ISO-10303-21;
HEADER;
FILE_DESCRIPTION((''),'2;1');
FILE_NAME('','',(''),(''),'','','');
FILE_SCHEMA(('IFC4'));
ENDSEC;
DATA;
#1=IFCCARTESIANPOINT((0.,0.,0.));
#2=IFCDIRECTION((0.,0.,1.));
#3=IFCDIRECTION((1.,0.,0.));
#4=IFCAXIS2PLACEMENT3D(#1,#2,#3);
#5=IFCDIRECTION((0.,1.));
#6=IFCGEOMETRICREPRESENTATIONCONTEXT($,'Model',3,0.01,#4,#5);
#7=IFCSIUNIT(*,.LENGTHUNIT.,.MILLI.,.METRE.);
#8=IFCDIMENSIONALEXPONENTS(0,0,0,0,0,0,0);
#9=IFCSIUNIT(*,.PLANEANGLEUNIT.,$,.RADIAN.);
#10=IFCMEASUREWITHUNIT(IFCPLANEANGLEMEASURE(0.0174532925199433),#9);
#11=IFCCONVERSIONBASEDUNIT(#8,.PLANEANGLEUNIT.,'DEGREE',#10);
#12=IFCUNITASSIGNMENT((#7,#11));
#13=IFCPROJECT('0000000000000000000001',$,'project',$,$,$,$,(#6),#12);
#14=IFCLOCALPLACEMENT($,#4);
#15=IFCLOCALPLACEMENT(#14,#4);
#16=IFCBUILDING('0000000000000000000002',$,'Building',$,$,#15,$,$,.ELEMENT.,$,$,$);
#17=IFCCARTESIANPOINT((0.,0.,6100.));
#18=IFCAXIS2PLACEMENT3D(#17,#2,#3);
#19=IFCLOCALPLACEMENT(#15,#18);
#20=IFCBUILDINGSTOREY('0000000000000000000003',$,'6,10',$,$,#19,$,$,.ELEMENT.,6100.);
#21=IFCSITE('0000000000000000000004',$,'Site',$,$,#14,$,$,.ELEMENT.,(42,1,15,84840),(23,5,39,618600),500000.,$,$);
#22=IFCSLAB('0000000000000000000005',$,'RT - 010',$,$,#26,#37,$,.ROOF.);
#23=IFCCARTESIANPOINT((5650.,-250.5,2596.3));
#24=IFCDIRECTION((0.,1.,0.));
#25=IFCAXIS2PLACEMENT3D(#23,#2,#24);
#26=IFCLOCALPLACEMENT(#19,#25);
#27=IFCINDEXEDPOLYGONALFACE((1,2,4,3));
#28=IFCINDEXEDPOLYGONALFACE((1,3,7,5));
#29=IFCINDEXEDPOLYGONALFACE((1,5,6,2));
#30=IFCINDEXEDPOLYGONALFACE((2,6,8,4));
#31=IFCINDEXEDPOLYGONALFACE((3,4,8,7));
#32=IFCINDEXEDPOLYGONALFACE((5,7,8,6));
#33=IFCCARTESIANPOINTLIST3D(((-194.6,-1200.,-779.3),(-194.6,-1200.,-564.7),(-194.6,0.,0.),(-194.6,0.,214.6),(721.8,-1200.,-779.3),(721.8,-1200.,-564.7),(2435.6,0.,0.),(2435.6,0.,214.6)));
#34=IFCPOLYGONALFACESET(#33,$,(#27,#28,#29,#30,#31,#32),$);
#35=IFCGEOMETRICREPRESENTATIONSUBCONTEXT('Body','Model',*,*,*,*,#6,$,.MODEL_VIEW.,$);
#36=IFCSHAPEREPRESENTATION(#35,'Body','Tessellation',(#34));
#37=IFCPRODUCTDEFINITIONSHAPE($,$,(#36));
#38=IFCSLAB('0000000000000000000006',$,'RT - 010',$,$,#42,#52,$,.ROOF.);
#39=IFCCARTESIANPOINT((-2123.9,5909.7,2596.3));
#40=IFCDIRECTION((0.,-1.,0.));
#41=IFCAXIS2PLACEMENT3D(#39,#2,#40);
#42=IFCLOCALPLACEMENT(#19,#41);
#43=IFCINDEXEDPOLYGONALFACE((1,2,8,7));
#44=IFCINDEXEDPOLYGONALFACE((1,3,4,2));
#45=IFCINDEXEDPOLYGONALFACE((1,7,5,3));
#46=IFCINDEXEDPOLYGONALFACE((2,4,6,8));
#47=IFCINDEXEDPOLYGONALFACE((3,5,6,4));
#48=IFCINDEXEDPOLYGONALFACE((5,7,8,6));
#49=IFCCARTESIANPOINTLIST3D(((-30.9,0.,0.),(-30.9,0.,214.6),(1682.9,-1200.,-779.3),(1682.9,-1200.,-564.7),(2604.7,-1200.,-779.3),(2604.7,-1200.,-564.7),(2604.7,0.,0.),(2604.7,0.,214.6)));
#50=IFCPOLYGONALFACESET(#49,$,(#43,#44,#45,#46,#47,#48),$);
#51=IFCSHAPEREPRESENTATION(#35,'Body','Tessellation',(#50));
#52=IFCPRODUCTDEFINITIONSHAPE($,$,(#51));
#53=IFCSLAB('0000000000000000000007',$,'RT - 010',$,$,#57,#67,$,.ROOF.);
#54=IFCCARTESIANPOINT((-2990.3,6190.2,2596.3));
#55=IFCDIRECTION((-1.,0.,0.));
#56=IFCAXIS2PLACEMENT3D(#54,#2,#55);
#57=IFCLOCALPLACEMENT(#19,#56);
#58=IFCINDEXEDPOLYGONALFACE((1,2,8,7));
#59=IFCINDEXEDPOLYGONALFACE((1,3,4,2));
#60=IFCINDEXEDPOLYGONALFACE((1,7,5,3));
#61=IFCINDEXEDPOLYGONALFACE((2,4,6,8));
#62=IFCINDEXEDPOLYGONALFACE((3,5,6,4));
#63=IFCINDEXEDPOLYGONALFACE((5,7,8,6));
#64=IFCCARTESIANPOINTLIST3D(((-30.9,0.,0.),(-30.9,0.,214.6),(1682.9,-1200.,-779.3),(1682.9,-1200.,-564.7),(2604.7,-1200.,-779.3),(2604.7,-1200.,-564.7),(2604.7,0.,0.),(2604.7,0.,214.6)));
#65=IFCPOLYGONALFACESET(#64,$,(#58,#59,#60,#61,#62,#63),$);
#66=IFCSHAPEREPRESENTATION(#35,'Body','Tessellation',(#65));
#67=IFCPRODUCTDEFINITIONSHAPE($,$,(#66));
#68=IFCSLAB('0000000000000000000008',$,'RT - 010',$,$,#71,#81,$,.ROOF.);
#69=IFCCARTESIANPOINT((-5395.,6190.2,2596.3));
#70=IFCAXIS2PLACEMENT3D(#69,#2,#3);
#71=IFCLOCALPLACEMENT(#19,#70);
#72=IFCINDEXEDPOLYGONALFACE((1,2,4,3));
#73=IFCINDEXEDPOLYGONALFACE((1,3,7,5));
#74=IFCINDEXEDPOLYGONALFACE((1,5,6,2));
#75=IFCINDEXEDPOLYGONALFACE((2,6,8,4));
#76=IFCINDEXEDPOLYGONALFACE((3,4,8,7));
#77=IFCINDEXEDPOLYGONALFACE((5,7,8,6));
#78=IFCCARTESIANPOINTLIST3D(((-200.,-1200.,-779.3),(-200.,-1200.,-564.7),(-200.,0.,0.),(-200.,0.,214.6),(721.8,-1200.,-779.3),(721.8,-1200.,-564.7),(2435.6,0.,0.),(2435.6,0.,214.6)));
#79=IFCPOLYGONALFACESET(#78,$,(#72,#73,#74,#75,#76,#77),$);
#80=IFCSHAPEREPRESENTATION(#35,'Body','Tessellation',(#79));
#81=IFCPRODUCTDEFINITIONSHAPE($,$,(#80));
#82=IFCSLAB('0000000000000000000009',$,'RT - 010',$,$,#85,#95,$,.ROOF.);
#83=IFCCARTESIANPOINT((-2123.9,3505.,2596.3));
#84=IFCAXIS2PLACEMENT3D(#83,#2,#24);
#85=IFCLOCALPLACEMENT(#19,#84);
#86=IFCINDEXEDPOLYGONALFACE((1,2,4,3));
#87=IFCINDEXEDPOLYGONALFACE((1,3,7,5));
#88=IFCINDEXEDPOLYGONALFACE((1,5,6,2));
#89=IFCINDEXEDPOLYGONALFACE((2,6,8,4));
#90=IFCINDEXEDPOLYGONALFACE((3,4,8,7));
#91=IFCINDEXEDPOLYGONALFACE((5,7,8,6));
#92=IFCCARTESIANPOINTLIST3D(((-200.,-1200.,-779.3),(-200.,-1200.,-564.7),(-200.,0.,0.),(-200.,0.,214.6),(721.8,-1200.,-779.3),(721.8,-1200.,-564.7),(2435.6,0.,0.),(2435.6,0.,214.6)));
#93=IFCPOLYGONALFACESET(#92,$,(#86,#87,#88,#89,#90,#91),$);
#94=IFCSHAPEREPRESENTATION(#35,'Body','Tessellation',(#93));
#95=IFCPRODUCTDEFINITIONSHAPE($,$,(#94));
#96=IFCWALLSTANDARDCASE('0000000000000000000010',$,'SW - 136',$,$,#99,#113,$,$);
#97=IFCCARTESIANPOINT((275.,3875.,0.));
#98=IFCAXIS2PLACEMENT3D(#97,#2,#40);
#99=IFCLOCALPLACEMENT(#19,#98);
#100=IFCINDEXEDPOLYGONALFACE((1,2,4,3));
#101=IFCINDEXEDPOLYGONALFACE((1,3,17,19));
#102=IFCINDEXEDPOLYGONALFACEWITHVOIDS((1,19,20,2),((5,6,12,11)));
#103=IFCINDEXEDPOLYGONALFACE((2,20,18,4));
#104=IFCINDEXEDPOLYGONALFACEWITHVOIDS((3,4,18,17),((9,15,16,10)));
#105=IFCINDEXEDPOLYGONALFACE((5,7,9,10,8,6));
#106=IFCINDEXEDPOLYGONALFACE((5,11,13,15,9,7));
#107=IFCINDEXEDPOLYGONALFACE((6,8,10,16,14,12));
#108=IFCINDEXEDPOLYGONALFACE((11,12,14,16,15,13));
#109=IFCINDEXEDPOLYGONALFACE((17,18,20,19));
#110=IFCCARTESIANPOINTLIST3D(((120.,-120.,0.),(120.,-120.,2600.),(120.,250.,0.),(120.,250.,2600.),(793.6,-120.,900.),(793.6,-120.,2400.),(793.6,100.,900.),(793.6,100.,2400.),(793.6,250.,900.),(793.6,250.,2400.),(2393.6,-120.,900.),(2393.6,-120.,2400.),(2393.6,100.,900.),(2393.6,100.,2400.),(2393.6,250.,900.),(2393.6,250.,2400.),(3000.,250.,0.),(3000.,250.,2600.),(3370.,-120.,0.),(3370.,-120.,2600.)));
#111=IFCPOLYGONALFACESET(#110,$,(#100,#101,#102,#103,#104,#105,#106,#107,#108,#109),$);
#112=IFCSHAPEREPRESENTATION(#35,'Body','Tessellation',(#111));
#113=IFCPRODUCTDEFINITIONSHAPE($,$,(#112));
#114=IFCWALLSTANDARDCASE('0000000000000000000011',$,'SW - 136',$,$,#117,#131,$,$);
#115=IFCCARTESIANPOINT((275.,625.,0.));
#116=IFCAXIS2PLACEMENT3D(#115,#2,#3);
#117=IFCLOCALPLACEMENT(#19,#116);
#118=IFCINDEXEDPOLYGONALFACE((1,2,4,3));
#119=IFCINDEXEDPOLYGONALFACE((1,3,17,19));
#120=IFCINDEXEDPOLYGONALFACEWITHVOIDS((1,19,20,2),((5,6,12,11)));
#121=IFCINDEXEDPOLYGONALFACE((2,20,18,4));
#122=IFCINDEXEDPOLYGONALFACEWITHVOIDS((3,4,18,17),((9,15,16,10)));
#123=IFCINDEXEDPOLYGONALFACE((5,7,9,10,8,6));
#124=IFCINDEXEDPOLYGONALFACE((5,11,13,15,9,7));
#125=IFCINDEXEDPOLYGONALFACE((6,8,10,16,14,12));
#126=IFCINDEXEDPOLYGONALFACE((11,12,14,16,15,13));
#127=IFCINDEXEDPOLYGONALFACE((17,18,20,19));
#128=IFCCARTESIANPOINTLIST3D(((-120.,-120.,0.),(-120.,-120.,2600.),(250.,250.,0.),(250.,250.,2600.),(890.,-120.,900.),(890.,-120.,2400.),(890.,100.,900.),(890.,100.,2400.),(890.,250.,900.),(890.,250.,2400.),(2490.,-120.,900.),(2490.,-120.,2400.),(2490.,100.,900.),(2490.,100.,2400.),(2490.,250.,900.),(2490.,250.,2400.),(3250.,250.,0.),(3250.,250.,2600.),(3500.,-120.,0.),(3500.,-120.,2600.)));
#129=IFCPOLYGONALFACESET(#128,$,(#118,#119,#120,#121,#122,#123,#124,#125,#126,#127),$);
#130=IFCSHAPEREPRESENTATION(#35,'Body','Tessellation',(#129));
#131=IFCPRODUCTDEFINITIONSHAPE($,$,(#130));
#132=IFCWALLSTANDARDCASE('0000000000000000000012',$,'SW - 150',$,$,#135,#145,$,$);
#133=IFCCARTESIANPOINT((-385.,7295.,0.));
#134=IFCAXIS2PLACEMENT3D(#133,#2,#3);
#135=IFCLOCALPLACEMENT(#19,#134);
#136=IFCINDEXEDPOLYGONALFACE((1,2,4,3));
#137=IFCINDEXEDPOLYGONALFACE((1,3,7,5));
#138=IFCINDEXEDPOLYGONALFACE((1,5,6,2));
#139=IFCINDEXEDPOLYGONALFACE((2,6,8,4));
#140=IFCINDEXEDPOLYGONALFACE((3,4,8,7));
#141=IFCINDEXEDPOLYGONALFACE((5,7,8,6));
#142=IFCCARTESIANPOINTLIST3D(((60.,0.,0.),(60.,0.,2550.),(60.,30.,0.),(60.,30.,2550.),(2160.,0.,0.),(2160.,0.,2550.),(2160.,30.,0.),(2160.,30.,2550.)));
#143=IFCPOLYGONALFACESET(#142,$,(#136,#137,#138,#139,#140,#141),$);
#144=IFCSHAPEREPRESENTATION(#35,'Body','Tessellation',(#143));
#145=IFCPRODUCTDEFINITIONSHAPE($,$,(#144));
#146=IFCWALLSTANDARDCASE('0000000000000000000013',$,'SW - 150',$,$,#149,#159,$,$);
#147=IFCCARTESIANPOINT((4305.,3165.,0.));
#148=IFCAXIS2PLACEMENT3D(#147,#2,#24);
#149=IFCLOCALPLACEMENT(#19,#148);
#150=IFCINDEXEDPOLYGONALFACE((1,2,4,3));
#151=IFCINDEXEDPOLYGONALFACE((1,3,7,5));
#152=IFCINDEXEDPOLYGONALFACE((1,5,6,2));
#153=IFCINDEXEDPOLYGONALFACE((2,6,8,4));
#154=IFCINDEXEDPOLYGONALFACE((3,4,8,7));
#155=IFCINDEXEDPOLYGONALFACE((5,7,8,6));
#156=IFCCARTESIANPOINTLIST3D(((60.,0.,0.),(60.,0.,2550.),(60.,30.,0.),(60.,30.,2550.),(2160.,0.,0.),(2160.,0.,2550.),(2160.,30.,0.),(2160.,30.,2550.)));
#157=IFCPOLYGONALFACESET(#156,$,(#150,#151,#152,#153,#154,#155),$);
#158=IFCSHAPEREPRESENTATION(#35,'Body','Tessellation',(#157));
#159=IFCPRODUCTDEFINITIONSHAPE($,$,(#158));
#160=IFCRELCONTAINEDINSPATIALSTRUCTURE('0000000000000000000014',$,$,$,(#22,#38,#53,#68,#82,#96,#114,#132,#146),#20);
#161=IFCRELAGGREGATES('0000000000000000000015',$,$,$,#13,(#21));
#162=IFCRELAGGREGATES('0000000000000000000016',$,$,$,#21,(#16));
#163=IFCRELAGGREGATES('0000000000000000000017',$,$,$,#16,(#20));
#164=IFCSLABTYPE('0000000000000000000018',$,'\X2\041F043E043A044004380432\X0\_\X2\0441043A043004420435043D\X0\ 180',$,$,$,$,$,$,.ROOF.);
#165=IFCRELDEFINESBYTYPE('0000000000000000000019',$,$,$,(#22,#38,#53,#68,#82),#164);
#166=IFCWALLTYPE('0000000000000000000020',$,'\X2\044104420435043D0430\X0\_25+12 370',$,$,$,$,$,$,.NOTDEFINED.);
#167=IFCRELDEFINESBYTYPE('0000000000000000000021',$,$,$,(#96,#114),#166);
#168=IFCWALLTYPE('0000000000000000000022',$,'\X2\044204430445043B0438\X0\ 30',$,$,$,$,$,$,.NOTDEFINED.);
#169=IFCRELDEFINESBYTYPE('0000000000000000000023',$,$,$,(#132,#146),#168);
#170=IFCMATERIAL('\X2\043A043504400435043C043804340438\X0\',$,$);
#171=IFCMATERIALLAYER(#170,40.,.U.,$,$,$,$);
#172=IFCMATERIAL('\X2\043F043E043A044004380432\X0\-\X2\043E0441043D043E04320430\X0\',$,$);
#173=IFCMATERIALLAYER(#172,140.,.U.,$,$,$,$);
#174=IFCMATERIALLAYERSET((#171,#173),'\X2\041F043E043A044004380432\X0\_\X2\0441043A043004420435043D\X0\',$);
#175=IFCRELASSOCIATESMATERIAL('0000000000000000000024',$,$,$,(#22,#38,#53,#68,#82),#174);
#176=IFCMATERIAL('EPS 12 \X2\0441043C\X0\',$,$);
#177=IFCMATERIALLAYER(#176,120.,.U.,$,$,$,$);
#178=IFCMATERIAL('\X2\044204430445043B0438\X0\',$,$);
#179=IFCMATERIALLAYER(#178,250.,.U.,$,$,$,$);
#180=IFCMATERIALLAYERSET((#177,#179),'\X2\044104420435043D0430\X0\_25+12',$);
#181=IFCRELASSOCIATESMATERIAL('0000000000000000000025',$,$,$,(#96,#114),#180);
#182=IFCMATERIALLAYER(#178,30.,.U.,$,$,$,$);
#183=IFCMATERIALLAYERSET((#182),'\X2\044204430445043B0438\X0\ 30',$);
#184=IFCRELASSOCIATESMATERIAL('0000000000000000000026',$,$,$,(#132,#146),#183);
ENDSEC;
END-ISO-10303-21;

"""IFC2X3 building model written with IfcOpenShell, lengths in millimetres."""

from ifc_helpers import new_model, entity, si_unit, converted_unit, direction, frame, origin_with_axes, origin_2d_with_axis, place, context, subcontext, project, spatial, polyline, rectangle, outline, extrude, material, layer, layer_set, layer_usage, type_object, element, save


model = new_model("IFC2X3")

# Units and contexts
model_context = context("Model", 3, precision=0.01, world=origin_with_axes(), true_north=direction((0.0, 1.0)))
body_context = subcontext(model_context, "Body", "Model", "MODEL_VIEW")
ifc_project = project(units=[si_unit("LENGTHUNIT", "METRE", prefix="MILLI"), converted_unit("PLANEANGLEUNIT", "DEGREE", entity("IfcPlaneAngleMeasure", 0.0174532925199433), si_unit("PLANEANGLEUNIT", "RADIAN"), dimensions=[0, 0, 0, 0, 0, 0, 0])], contexts=[model_context])

# Site, building, storey
site_placement = place(None, origin_with_axes())
site = spatial("IfcSite", under=ifc_project, at=site_placement, Name="Site", CompositionType="ELEMENT", RefLatitude=(42, 1, 15, 84840), RefLongitude=(23, 5, 39, 618600), RefElevation=500000.0)
building_placement = place(site_placement, origin_with_axes())
building = spatial("IfcBuilding", under=site, at=building_placement, Name="Building", CompositionType="ELEMENT")
storey_placement = place(building_placement, frame((0.0, 0.0, 6100.0), z_axis=(0.0, 0.0, 1.0), x_axis=(1.0, 0.0, 0.0)))
storey = spatial("IfcBuildingStorey", under=building, at=storey_placement, Name="6,10", CompositionType="ELEMENT", Elevation=6100.0)

# Slabs
ifc_material_1 = material(Name="керемиди")
ifc_layer_1 = layer(ifc_material_1, 40.0, ventilated="UNKNOWN")
ifc_material_2 = material(Name="покрив-основа")
ifc_layer_2 = layer(ifc_material_2, 140.0, ventilated="UNKNOWN")
ifc_layer_set_1 = layer_set([ifc_layer_1, ifc_layer_2], Name="Покрив_скатен")
ifc_layer_usage_1 = layer_usage(ifc_layer_set_1, "AXIS3", "NEGATIVE", 180.0)
slab_type_1 = type_object("IfcSlabType", Name="Покрив_скатен 180", PredefinedType="ROOF")
slab_1_placement = place(storey_placement, frame((5650.0, -250.5, 2596.3), z_axis=(0.0, 0.0, 1.0), x_axis=(0.0, 1.0, 0.0)))
element("IfcSlab", 1, at=slab_1_placement, inside=storey, type_object=slab_type_1, material=ifc_layer_usage_1, Name="RT - 010", PredefinedType="ROOF", context=body_context, shape_type="SweptSolid", body=[
    extrude(outline(polyline([(2435.6, 0.0), (-194.6, 0.0), (-194.6, -1430.8), (721.8, -1430.8), (2435.6, 0.0)])), frame((0.0, 0.0, 0.0), z_axis=(0.0, -0.544639, 0.838671), x_axis=(1.0, 0.0, 0.0)), (0.0, 0.544639, 0.838671), 214.6),
])
ifc_layer_usage_2 = layer_usage(ifc_layer_set_1, "AXIS3", "NEGATIVE", 180.0)
slab_2_placement = place(storey_placement, frame((-2123.9, 5909.7, 2596.3), z_axis=(0.0, 0.0, 1.0), x_axis=(0.0, -1.0, 0.0)))
element("IfcSlab", 2, at=slab_2_placement, inside=storey, type_object=slab_type_1, material=ifc_layer_usage_2, Name="RT - 010", PredefinedType="ROOF", context=body_context, shape_type="SweptSolid", body=[
    extrude(outline(polyline([(-30.9, 0.0), (1682.9, -1430.8), (2604.7, -1430.8), (2604.7, 0.0), (-30.9, 0.0)])), frame((0.0, 0.0, 0.0), z_axis=(0.0, -0.544639, 0.838671), x_axis=(1.0, 0.0, 0.0)), (0.0, 0.544639, 0.838671), 214.6),
])
ifc_layer_usage_3 = layer_usage(ifc_layer_set_1, "AXIS3", "NEGATIVE", 180.0)
slab_3_placement = place(storey_placement, frame((-2990.3, 6190.2, 2596.3), z_axis=(0.0, 0.0, 1.0), x_axis=(-1.0, 0.0, 0.0)))
element("IfcSlab", 3, at=slab_3_placement, inside=storey, type_object=slab_type_1, material=ifc_layer_usage_3, Name="RT - 010", PredefinedType="ROOF", context=body_context, shape_type="SweptSolid", body=[
    extrude(outline(polyline([(-30.9, 0.0), (1682.9, -1430.8), (2604.7, -1430.8), (2604.7, 0.0), (-30.9, 0.0)])), frame((0.0, 0.0, 0.0), z_axis=(0.0, -0.544639, 0.838671), x_axis=(1.0, 0.0, 0.0)), (0.0, 0.544639, 0.838671), 214.6),
])
ifc_layer_usage_4 = layer_usage(ifc_layer_set_1, "AXIS3", "NEGATIVE", 180.0)
slab_4_placement = place(storey_placement, frame((-5395.0, 6190.2, 2596.3), z_axis=(0.0, 0.0, 1.0), x_axis=(1.0, 0.0, 0.0)))
element("IfcSlab", 4, at=slab_4_placement, inside=storey, type_object=slab_type_1, material=ifc_layer_usage_4, Name="RT - 010", PredefinedType="ROOF", context=body_context, shape_type="SweptSolid", body=[
    extrude(outline(polyline([(2435.6, 0.0), (-200.0, 0.0), (-200.0, -1430.8), (721.8, -1430.8), (2435.6, 0.0)])), frame((0.0, 0.0, 0.0), z_axis=(0.0, -0.544639, 0.838671), x_axis=(1.0, 0.0, 0.0)), (0.0, 0.544639, 0.838671), 214.6),
])
ifc_layer_usage_5 = layer_usage(ifc_layer_set_1, "AXIS3", "NEGATIVE", 180.0)
slab_5_placement = place(storey_placement, frame((-2123.9, 3505.0, 2596.3), z_axis=(0.0, 0.0, 1.0), x_axis=(0.0, 1.0, 0.0)))
element("IfcSlab", 5, at=slab_5_placement, inside=storey, type_object=slab_type_1, material=ifc_layer_usage_5, Name="RT - 010", PredefinedType="ROOF", context=body_context, shape_type="SweptSolid", body=[
    extrude(outline(polyline([(2435.6, 0.0), (-200.0, 0.0), (-200.0, -1430.8), (721.8, -1430.8), (2435.6, 0.0)])), frame((0.0, 0.0, 0.0), z_axis=(0.0, -0.544639, 0.838671), x_axis=(1.0, 0.0, 0.0)), (0.0, 0.544639, 0.838671), 214.6),
])

# Shared definitions
ifc_material_3 = material(Name="EPS 12 см")
ifc_layer_3 = layer(ifc_material_3, 120.0, ventilated="UNKNOWN")
ifc_material_4 = material(Name="тухли")
ifc_layer_4 = layer(ifc_material_4, 250.0, ventilated="UNKNOWN")
ifc_layer_set_2 = layer_set([ifc_layer_3, ifc_layer_4], Name="стена_25+12")
wall_type_1 = type_object("IfcWallType", Name="стена_25+12 370", PredefinedType="NOTDEFINED")

# Walls, openings
ifc_layer_usage_6 = layer_usage(ifc_layer_set_2, "AXIS2", "POSITIVE", -120.0)
wall_1_placement = place(storey_placement, frame((275.0, 3875.0, 0.0), z_axis=(0.0, 0.0, 1.0), x_axis=(0.0, -1.0, 0.0)))
wall_1 = element("IfcWallStandardCase", 6, at=wall_1_placement, inside=storey, type_object=wall_type_1, material=ifc_layer_usage_6, Name="SW - 136", context=body_context, shape_type="SweptSolid", body=[
    extrude(outline(polyline([(120.0, -120.0), (3370.0, -120.0), (3000.0, 250.0), (120.0, 250.0), (120.0, -120.0)])), origin_with_axes(), (0.0, 0.0, 1.0), 2600.0),
])
opening_1_placement = place(wall_1_placement, frame((1593.6, 0.0, 900.0), z_axis=(0.0, 0.0, 1.0), x_axis=(1.0, 0.0, 0.0)))
element("IfcOpeningElement", 7, at=opening_1_placement, cuts=wall_1, context=body_context, shape_type="SweptSolid", body=[
    extrude(rectangle(XDim=1600.0, YDim=1500.0, at=origin_2d_with_axis()), frame((0.0, 100.0, 750.0), z_axis=(0.0, 1.0, 0.0), x_axis=(1.0, 0.0, 0.0)), (0.0, 0.0, -1.0), 590.0),
    extrude(rectangle(XDim=1600.0, YDim=1500.0, at=origin_2d_with_axis()), frame((0.0, 100.0, 750.0), z_axis=(0.0, -1.0, 0.0), x_axis=(1.0, 0.0, 0.0)), (0.0, 0.0, -1.0), 520.0),
])
ifc_layer_usage_7 = layer_usage(ifc_layer_set_2, "AXIS2", "POSITIVE", -120.0)
wall_2_placement = place(storey_placement, frame((275.0, 625.0, 0.0), z_axis=(0.0, 0.0, 1.0), x_axis=(1.0, 0.0, 0.0)))
wall_2 = element("IfcWallStandardCase", 8, at=wall_2_placement, inside=storey, type_object=wall_type_1, material=ifc_layer_usage_7, Name="SW - 136", context=body_context, shape_type="SweptSolid", body=[
    extrude(outline(polyline([(-120.0, -120.0), (3500.0, -120.0), (3250.0, 250.0), (250.0, 250.0), (-120.0, -120.0)])), origin_with_axes(), (0.0, 0.0, 1.0), 2600.0),
])
opening_2_placement = place(wall_2_placement, frame((1690.0, 0.0, 900.0), z_axis=(0.0, 0.0, 1.0), x_axis=(1.0, 0.0, 0.0)))
element("IfcOpeningElement", 9, at=opening_2_placement, cuts=wall_2, context=body_context, shape_type="SweptSolid", body=[
    extrude(rectangle(XDim=1600.0, YDim=1500.0, at=origin_2d_with_axis()), frame((0.0, 100.0, 750.0), z_axis=(0.0, -1.0, 0.0), x_axis=(-1.0, 0.0, 0.0)), (0.0, 0.0, 1.0), 590.0),
    extrude(rectangle(XDim=1600.0, YDim=1500.0, at=origin_2d_with_axis()), frame((0.0, 100.0, 750.0), z_axis=(0.0, 1.0, 0.0), x_axis=(-1.0, 0.0, 0.0)), (0.0, 0.0, 1.0), 520.0),
])

# Walls
ifc_layer_5 = layer(ifc_material_4, 30.0, ventilated="UNKNOWN")
ifc_layer_set_3 = layer_set([ifc_layer_5], Name="тухли 30")
ifc_layer_usage_8 = layer_usage(ifc_layer_set_3, "AXIS2", "POSITIVE", 0.0)
wall_type_2 = type_object("IfcWallType", Name="тухли 30", PredefinedType="NOTDEFINED")
wall_3_placement = place(storey_placement, frame((-385.0, 7295.0, 0.0), z_axis=(0.0, 0.0, 1.0), x_axis=(1.0, 0.0, 0.0)))
element("IfcWallStandardCase", 10, at=wall_3_placement, inside=storey, type_object=wall_type_2, material=ifc_layer_usage_8, Name="SW - 150", context=body_context, shape_type="SweptSolid", body=[
    extrude(outline(polyline([(60.0, 0.0), (2160.0, 0.0), (2160.0, 30.0), (60.0, 30.0), (60.0, 0.0)])), origin_with_axes(), (0.0, 0.0, 1.0), 2550.0),
])
ifc_layer_usage_9 = layer_usage(ifc_layer_set_3, "AXIS2", "POSITIVE", 0.0)
wall_4_placement = place(storey_placement, frame((4305.0, 3165.0, 0.0), z_axis=(0.0, 0.0, 1.0), x_axis=(0.0, 1.0, 0.0)))
element("IfcWallStandardCase", 11, at=wall_4_placement, inside=storey, type_object=wall_type_2, material=ifc_layer_usage_9, Name="SW - 150", context=body_context, shape_type="SweptSolid", body=[
    extrude(outline(polyline([(60.0, 0.0), (2160.0, 0.0), (2160.0, 30.0), (60.0, 30.0), (60.0, 0.0)])), origin_with_axes(), (0.0, 0.0, 1.0), 2550.0),
])

save(model, "model.ifc")
